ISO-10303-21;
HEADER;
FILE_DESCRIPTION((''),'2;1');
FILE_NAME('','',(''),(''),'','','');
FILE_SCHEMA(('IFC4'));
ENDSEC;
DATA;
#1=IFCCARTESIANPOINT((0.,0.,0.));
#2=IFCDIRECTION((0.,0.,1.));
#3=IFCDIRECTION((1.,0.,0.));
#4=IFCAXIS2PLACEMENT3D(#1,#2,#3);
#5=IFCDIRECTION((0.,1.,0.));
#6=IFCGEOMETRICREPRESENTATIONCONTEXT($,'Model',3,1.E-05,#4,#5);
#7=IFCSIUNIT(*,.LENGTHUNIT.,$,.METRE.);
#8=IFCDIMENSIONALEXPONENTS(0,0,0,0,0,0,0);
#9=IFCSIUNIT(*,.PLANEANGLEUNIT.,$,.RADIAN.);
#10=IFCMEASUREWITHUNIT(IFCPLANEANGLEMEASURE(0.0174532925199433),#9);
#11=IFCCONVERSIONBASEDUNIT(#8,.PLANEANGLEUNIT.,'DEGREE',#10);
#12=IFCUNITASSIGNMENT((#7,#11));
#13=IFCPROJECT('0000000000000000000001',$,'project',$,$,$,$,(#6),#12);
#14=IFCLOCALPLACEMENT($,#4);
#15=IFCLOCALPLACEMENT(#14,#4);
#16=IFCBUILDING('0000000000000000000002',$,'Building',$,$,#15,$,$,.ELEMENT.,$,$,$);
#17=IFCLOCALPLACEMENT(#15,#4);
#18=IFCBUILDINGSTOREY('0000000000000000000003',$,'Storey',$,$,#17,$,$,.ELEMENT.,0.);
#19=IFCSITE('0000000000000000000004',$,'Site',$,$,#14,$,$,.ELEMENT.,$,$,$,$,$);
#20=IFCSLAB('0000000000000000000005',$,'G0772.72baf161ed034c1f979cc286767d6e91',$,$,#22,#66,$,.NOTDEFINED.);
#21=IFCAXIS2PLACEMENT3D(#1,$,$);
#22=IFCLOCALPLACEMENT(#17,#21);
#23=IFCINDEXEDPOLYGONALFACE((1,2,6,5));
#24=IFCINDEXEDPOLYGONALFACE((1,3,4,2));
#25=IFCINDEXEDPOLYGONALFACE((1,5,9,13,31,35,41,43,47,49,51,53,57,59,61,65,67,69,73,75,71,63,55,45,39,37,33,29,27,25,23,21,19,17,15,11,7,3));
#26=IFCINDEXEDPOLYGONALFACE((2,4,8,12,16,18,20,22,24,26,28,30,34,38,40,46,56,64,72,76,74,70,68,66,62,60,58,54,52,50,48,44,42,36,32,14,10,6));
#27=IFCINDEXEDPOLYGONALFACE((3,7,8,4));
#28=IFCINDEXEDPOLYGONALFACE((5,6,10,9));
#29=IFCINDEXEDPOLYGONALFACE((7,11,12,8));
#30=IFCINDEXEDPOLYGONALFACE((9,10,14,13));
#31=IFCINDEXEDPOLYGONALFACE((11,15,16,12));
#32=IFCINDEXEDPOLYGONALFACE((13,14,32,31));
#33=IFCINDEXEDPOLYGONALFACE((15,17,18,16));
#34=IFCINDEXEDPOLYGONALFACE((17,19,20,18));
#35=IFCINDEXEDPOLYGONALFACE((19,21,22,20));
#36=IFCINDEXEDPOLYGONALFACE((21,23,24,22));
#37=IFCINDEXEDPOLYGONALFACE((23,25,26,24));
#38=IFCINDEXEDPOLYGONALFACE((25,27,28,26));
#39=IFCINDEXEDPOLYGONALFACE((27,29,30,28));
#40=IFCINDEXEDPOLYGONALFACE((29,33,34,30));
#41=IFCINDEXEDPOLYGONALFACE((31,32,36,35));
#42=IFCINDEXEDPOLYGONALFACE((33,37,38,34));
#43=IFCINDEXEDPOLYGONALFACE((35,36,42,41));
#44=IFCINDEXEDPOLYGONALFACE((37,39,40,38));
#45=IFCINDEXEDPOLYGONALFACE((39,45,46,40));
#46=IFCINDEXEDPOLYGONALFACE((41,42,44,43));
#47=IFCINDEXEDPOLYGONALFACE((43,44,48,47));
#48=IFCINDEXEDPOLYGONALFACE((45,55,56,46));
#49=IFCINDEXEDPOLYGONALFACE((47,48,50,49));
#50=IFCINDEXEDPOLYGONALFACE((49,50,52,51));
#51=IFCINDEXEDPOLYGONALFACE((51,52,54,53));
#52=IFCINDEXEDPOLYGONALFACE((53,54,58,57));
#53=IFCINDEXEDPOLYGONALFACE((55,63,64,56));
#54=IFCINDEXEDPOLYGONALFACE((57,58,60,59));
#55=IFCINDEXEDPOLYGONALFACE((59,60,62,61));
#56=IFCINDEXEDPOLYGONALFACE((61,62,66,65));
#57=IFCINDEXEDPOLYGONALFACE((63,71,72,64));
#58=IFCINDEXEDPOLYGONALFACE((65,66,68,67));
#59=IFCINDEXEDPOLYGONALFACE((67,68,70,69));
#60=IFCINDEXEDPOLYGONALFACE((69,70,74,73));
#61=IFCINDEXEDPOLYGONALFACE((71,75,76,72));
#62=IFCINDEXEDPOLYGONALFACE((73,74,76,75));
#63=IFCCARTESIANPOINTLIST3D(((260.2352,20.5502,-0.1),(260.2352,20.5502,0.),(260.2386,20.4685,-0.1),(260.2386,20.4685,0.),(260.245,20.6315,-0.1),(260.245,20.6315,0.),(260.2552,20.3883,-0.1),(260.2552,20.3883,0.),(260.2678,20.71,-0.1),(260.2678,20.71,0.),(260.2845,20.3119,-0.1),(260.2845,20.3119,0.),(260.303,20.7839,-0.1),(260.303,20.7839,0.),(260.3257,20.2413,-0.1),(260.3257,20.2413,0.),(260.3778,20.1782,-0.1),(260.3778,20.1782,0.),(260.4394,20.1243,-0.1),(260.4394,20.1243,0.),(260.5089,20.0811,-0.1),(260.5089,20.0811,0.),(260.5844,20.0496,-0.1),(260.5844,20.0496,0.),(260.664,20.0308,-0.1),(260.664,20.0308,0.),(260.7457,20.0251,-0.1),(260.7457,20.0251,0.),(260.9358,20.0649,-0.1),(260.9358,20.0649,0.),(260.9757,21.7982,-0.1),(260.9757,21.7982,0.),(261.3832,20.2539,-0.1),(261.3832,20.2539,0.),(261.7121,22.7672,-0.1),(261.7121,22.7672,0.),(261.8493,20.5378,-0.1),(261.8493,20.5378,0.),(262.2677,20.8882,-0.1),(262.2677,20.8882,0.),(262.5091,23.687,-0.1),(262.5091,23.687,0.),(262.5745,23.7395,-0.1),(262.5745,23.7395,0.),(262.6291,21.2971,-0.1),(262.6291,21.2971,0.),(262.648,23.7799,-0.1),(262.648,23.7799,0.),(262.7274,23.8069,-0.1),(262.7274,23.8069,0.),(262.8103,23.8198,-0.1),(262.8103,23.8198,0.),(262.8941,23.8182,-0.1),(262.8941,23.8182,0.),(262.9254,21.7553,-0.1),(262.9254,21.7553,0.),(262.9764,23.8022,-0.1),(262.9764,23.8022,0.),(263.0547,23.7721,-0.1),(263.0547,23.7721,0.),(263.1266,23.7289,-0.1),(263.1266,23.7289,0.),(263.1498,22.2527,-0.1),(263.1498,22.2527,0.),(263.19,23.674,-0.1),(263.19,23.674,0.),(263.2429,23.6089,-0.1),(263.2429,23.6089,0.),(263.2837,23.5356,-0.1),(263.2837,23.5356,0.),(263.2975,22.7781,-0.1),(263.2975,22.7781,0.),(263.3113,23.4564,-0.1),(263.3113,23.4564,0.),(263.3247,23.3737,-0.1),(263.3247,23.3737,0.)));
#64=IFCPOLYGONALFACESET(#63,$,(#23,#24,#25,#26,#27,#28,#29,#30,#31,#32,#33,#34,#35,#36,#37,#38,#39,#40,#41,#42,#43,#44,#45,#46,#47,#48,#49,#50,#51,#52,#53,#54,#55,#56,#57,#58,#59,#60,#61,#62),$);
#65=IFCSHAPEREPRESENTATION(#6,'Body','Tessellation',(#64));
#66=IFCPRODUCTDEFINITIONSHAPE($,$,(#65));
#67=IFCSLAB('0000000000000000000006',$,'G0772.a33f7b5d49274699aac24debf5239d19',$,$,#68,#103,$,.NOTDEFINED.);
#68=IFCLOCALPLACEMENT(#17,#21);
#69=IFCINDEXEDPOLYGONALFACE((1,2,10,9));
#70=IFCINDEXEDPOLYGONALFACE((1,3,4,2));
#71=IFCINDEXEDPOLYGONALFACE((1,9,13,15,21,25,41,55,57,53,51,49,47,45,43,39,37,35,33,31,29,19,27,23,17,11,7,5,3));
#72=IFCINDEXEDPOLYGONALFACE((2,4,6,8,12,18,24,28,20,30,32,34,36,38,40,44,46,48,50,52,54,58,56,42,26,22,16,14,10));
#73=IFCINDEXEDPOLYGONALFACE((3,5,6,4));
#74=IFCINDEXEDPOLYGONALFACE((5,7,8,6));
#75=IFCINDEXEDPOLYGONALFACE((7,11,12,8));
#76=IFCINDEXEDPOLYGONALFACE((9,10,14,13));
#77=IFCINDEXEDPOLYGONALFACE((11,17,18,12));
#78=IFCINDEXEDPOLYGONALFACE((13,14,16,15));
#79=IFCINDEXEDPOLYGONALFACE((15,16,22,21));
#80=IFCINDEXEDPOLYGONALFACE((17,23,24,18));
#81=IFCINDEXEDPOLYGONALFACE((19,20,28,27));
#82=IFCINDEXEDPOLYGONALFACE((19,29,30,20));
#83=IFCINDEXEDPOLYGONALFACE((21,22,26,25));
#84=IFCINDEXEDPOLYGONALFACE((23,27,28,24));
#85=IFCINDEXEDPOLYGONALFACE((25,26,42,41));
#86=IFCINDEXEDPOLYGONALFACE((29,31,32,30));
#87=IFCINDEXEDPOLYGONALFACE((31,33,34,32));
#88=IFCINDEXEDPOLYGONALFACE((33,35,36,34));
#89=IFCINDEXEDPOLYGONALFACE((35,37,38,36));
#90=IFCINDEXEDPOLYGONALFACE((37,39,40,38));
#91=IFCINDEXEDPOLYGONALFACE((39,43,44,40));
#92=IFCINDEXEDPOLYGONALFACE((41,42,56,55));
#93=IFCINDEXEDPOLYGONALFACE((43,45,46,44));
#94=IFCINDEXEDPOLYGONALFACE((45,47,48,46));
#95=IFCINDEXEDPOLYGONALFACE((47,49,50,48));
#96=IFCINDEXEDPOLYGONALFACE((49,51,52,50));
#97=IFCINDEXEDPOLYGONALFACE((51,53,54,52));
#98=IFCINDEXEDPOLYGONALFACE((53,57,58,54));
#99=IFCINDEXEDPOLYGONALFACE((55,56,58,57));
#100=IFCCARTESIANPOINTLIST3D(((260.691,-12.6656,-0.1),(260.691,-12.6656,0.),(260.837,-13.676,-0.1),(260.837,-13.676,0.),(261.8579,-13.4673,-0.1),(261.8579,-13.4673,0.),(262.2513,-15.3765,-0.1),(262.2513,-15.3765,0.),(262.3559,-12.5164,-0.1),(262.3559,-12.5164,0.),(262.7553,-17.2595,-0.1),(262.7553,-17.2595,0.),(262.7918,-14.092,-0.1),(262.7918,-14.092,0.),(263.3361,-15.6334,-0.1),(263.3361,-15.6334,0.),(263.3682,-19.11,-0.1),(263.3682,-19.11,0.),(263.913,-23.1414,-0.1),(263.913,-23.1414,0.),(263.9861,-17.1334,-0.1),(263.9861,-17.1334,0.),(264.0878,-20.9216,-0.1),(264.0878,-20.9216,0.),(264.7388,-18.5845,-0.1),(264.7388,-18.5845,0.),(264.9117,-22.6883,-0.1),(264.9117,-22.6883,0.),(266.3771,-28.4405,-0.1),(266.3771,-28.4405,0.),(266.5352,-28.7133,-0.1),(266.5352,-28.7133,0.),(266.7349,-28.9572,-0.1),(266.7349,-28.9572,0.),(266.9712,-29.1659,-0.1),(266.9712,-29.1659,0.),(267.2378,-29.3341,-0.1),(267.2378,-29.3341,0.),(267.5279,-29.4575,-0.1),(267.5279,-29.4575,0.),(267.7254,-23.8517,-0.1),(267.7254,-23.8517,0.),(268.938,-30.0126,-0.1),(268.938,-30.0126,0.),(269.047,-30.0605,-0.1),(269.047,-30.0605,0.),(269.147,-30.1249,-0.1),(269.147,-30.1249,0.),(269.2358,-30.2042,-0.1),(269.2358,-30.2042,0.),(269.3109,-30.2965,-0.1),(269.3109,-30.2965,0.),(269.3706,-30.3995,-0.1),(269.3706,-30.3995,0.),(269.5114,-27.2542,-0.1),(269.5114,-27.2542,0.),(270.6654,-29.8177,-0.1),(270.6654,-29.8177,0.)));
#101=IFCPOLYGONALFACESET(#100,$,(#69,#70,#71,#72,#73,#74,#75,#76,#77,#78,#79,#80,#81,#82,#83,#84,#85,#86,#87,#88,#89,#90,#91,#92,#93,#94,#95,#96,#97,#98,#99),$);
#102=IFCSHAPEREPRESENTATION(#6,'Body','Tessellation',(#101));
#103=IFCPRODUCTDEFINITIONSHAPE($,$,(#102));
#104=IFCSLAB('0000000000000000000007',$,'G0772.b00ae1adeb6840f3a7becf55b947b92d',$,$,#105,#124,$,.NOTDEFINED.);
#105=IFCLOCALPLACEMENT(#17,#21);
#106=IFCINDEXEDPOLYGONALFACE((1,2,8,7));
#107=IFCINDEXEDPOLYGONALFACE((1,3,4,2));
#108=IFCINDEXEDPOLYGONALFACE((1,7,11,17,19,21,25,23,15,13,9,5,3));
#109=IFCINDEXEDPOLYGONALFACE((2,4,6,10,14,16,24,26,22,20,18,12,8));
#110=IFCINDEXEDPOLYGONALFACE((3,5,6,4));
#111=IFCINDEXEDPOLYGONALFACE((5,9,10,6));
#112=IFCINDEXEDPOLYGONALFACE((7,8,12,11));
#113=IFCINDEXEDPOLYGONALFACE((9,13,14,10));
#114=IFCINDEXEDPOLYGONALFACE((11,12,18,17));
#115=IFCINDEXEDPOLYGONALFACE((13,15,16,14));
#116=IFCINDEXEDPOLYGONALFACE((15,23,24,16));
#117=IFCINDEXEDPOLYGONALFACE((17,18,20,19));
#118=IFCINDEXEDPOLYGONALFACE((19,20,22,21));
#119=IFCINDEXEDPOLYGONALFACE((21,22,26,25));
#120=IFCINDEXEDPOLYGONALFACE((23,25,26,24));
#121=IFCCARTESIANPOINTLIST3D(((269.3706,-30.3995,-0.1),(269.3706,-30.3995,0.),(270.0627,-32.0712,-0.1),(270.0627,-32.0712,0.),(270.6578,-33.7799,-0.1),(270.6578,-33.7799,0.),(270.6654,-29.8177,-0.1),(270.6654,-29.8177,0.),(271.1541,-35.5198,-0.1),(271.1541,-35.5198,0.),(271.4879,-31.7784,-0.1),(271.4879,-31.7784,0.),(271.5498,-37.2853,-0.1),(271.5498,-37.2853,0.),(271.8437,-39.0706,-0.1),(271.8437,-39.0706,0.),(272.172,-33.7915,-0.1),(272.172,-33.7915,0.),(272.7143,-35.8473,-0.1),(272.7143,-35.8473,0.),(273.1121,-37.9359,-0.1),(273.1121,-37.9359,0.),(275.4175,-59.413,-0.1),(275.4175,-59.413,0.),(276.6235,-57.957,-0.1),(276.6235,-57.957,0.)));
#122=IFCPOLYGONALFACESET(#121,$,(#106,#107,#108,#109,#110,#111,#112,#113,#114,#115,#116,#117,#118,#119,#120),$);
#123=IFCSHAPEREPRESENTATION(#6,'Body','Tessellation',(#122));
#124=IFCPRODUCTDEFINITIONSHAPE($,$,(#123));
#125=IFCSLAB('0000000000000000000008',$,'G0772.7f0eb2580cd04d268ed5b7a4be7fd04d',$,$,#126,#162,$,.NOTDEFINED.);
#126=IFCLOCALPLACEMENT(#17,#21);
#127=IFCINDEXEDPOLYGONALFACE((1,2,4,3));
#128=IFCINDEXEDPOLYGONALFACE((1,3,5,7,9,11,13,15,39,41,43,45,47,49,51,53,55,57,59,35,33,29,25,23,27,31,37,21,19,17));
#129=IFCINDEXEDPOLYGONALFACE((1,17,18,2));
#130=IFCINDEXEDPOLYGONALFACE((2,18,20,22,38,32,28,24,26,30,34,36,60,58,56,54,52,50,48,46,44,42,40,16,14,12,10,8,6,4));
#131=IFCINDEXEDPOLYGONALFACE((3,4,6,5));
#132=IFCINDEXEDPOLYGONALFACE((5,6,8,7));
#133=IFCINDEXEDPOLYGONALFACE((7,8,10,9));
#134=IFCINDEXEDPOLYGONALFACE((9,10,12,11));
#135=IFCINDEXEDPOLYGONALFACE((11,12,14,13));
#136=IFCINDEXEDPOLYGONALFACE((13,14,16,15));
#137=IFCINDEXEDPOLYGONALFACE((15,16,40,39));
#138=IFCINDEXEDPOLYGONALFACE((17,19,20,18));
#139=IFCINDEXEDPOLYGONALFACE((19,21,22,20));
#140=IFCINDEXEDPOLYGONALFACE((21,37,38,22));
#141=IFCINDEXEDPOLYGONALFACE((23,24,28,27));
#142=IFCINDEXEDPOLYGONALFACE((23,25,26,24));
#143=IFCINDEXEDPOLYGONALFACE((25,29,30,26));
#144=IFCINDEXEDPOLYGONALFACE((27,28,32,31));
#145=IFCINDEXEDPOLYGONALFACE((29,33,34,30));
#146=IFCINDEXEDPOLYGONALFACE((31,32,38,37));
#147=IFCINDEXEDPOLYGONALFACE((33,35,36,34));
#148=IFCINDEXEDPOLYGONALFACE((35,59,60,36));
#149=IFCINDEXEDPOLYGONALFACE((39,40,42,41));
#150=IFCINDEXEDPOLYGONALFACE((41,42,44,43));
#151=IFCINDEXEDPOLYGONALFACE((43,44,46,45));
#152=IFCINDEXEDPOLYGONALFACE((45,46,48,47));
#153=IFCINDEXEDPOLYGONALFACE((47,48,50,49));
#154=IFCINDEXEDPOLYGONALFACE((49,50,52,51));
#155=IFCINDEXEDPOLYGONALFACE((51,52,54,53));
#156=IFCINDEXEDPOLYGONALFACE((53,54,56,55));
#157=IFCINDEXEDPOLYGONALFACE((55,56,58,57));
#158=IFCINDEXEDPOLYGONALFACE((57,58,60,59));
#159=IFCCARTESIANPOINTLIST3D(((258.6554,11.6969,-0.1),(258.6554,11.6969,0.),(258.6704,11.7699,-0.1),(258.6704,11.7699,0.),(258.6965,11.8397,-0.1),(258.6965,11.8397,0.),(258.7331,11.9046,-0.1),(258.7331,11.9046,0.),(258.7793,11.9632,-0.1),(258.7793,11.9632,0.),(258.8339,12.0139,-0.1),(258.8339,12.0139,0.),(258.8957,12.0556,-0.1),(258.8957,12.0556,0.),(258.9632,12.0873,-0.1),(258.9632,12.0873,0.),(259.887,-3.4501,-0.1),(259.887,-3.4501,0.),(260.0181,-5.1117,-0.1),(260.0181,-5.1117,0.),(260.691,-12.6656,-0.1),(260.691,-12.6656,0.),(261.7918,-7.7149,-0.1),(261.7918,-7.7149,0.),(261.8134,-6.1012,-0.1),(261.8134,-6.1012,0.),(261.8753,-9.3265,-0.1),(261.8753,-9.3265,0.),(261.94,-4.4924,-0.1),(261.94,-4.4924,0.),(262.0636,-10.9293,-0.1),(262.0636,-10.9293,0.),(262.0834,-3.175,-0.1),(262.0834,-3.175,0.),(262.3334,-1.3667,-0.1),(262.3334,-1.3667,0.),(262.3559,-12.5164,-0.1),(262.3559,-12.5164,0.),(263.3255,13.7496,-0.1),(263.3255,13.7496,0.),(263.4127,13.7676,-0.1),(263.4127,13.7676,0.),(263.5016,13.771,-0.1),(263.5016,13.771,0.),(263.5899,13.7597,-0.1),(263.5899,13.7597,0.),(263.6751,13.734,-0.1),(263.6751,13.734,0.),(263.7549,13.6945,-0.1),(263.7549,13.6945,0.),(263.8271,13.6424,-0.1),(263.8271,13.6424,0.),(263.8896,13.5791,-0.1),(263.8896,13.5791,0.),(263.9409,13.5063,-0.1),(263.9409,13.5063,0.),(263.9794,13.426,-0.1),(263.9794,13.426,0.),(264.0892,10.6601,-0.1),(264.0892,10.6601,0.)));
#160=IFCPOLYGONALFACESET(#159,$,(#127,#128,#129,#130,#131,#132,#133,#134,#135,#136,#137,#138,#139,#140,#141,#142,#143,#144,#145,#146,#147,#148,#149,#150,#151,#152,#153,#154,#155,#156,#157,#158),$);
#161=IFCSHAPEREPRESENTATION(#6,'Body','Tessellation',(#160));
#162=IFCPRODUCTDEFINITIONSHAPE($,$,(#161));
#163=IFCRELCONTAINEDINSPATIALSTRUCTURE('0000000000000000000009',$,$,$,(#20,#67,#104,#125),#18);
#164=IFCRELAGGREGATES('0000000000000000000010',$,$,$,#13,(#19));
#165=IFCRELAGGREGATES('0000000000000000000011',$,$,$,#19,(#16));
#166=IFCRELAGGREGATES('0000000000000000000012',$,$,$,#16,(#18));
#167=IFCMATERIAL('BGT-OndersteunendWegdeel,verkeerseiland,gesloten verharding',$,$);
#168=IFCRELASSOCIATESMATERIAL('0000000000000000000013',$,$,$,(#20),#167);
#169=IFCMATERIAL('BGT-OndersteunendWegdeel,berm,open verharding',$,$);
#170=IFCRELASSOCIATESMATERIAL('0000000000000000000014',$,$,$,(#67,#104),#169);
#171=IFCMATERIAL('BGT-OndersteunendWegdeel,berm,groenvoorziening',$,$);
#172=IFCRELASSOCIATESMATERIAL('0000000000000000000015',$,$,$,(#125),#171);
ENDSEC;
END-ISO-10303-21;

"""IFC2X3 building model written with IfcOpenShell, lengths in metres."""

from ifc_helpers import new_model, entity, si_unit, converted_unit, direction, frame, origin_with_axes, place, context, project, spatial, polyline, outline, extrude, material, element, save


model = new_model("IFC2X3")

# Units and contexts
model_context = context("Model", 3, precision=1e-05, world=origin_with_axes(), true_north=direction((0.0, 1.0, 0.0)))
ifc_project = project(units=[si_unit("LENGTHUNIT", "METRE"), converted_unit("PLANEANGLEUNIT", "DEGREE", entity("IfcPlaneAngleMeasure", 0.0174532925199433), si_unit("PLANEANGLEUNIT", "RADIAN"), dimensions=[0, 0, 0, 0, 0, 0, 0])], contexts=[model_context])

# Site, building, storey
site_placement = place(None, origin_with_axes())
site = spatial("IfcSite", under=ifc_project, at=site_placement, Name="Site", CompositionType="ELEMENT")
building_placement = place(site_placement, origin_with_axes())
building = spatial("IfcBuilding", under=site, at=building_placement, Name="Building", CompositionType="ELEMENT")
storey_placement = place(building_placement, origin_with_axes())
storey = spatial("IfcBuildingStorey", under=building, at=storey_placement, Name="Storey", CompositionType="ELEMENT", Elevation=0.0)

# Slabs
ifc_material_1 = material(Name="BGT-OndersteunendWegdeel,berm,open verharding")
ifc_material_2 = material(Name="BGT-OndersteunendWegdeel,berm,groenvoorziening")
ifc_material_3 = material(Name="BGT-OndersteunendWegdeel,verkeerseiland,gesloten verharding")
slab_1_placement = place(storey_placement, frame((0.0, 0.0, -0.1), z_axis=(0.0, 0.0, 1.0), x_axis=(1.0, 0.0, 0.0)))
element("IfcSlab", 1, at=slab_1_placement, inside=storey, material=ifc_material_3, Name="G0772.72baf161ed034c1f979cc286767d6e91", PredefinedType="NOTDEFINED", context=model_context, shape_type="SweptSolid", body=[
    extrude(outline(polyline([(262.5745, 23.7395), (262.648, 23.7799), (262.7274, 23.8069), (262.8103, 23.8198), (262.8941, 23.8182), (262.9764, 23.8022), (263.0547, 23.7721), (263.1266, 23.7289), (263.19, 23.674), (263.2429, 23.6089), (263.2837, 23.5356), (263.3113, 23.4564), (263.3247, 23.3737), (263.2975, 22.7781), (263.1498, 22.2527), (262.9254, 21.7553), (262.6291, 21.2971), (262.2677, 20.8882), (261.8493, 20.5378), (261.3832, 20.2539), (260.9358, 20.0649), (260.7457, 20.0251), (260.664, 20.0308), (260.5844, 20.0496), (260.5089, 20.0811), (260.4394, 20.1243), (260.3778, 20.1782), (260.3257, 20.2413), (260.2845, 20.3119), (260.2552, 20.3883), (260.2386, 20.4685), (260.2352, 20.5502), (260.245, 20.6315), (260.2678, 20.71), (260.303, 20.7839), (260.9757, 21.7982), (261.7121, 22.7672), (262.5091, 23.687), (262.5745, 23.7395)])), origin_with_axes(), (0.0, 0.0, 1.0), 0.1),
])
slab_2_placement = place(storey_placement, frame((0.0, 0.0, -0.1), z_axis=(0.0, 0.0, 1.0), x_axis=(1.0, 0.0, 0.0)))
element("IfcSlab", 2, at=slab_2_placement, inside=storey, material=ifc_material_1, Name="G0772.a33f7b5d49274699aac24debf5239d19", PredefinedType="NOTDEFINED", context=model_context, shape_type="SweptSolid", body=[
    extrude(outline(polyline([(267.7254, -23.8517), (269.5114, -27.2542), (270.6654, -29.8177), (269.3706, -30.3995), (269.3109, -30.2965), (269.2358, -30.2042), (269.147, -30.1249), (269.047, -30.0605), (268.938, -30.0126), (267.5279, -29.4575), (267.2378, -29.3341), (266.9712, -29.1659), (266.7349, -28.9572), (266.5352, -28.7133), (266.3771, -28.4405), (263.913, -23.1414), (264.9117, -22.6883), (264.0878, -20.9216), (263.3682, -19.11), (262.7553, -17.2595), (262.2513, -15.3765), (261.8579, -13.4673), (260.837, -13.676), (260.691, -12.6656), (262.3559, -12.5164), (262.7918, -14.092), (263.3361, -15.6334), (263.9861, -17.1334), (264.7388, -18.5845), (267.7254, -23.8517)])), origin_with_axes(), (0.0, 0.0, 1.0), 0.1),
])
slab_3_placement = place(storey_placement, frame((0.0, 0.0, -0.1), z_axis=(0.0, 0.0, 1.0), x_axis=(1.0, 0.0, 0.0)))
element("IfcSlab", 3, at=slab_3_placement, inside=storey, material=ifc_material_1, Name="G0772.b00ae1adeb6840f3a7becf55b947b92d", PredefinedType="NOTDEFINED", context=model_context, shape_type="SweptSolid", body=[
    extrude(outline(polyline([(271.8437, -39.0706), (271.5498, -37.2853), (271.1541, -35.5198), (270.6578, -33.7799), (270.0627, -32.0712), (269.3706, -30.3995), (270.6654, -29.8177), (271.4879, -31.7784), (272.172, -33.7915), (272.7143, -35.8473), (273.1121, -37.9359), (276.6235, -57.957), (275.4175, -59.413), (271.8437, -39.0706)])), origin_with_axes(), (0.0, 0.0, 1.0), 0.1),
])
slab_4_placement = place(storey_placement, frame((0.0, 0.0, -0.1), z_axis=(0.0, 0.0, 1.0), x_axis=(1.0, 0.0, 0.0)))
element("IfcSlab", 4, at=slab_4_placement, inside=storey, material=ifc_material_2, Name="G0772.7f0eb2580cd04d268ed5b7a4be7fd04d", PredefinedType="NOTDEFINED", context=model_context, shape_type="SweptSolid", body=[
    extrude(outline(polyline([(262.3334, -1.3667), (262.0834, -3.175), (261.94, -4.4924), (261.8134, -6.1012), (261.7918, -7.7149), (261.8753, -9.3265), (262.0636, -10.9293), (262.3559, -12.5164), (260.691, -12.6656), (260.0181, -5.1117), (259.887, -3.4501), (258.6554, 11.6969), (258.6704, 11.7699), (258.6965, 11.8397), (258.7331, 11.9046), (258.7793, 11.9632), (258.8339, 12.0139), (258.8957, 12.0556), (258.9632, 12.0873), (263.3255, 13.7496), (263.4127, 13.7676), (263.5016, 13.771), (263.5899, 13.7597), (263.6751, 13.734), (263.7549, 13.6945), (263.8271, 13.6424), (263.8896, 13.5791), (263.9409, 13.5063), (263.9794, 13.426), (264.0892, 10.6601), (262.3334, -1.3667)])), origin_with_axes(), (0.0, 0.0, 1.0), 0.1),
])

save(model, "model.ifc")
